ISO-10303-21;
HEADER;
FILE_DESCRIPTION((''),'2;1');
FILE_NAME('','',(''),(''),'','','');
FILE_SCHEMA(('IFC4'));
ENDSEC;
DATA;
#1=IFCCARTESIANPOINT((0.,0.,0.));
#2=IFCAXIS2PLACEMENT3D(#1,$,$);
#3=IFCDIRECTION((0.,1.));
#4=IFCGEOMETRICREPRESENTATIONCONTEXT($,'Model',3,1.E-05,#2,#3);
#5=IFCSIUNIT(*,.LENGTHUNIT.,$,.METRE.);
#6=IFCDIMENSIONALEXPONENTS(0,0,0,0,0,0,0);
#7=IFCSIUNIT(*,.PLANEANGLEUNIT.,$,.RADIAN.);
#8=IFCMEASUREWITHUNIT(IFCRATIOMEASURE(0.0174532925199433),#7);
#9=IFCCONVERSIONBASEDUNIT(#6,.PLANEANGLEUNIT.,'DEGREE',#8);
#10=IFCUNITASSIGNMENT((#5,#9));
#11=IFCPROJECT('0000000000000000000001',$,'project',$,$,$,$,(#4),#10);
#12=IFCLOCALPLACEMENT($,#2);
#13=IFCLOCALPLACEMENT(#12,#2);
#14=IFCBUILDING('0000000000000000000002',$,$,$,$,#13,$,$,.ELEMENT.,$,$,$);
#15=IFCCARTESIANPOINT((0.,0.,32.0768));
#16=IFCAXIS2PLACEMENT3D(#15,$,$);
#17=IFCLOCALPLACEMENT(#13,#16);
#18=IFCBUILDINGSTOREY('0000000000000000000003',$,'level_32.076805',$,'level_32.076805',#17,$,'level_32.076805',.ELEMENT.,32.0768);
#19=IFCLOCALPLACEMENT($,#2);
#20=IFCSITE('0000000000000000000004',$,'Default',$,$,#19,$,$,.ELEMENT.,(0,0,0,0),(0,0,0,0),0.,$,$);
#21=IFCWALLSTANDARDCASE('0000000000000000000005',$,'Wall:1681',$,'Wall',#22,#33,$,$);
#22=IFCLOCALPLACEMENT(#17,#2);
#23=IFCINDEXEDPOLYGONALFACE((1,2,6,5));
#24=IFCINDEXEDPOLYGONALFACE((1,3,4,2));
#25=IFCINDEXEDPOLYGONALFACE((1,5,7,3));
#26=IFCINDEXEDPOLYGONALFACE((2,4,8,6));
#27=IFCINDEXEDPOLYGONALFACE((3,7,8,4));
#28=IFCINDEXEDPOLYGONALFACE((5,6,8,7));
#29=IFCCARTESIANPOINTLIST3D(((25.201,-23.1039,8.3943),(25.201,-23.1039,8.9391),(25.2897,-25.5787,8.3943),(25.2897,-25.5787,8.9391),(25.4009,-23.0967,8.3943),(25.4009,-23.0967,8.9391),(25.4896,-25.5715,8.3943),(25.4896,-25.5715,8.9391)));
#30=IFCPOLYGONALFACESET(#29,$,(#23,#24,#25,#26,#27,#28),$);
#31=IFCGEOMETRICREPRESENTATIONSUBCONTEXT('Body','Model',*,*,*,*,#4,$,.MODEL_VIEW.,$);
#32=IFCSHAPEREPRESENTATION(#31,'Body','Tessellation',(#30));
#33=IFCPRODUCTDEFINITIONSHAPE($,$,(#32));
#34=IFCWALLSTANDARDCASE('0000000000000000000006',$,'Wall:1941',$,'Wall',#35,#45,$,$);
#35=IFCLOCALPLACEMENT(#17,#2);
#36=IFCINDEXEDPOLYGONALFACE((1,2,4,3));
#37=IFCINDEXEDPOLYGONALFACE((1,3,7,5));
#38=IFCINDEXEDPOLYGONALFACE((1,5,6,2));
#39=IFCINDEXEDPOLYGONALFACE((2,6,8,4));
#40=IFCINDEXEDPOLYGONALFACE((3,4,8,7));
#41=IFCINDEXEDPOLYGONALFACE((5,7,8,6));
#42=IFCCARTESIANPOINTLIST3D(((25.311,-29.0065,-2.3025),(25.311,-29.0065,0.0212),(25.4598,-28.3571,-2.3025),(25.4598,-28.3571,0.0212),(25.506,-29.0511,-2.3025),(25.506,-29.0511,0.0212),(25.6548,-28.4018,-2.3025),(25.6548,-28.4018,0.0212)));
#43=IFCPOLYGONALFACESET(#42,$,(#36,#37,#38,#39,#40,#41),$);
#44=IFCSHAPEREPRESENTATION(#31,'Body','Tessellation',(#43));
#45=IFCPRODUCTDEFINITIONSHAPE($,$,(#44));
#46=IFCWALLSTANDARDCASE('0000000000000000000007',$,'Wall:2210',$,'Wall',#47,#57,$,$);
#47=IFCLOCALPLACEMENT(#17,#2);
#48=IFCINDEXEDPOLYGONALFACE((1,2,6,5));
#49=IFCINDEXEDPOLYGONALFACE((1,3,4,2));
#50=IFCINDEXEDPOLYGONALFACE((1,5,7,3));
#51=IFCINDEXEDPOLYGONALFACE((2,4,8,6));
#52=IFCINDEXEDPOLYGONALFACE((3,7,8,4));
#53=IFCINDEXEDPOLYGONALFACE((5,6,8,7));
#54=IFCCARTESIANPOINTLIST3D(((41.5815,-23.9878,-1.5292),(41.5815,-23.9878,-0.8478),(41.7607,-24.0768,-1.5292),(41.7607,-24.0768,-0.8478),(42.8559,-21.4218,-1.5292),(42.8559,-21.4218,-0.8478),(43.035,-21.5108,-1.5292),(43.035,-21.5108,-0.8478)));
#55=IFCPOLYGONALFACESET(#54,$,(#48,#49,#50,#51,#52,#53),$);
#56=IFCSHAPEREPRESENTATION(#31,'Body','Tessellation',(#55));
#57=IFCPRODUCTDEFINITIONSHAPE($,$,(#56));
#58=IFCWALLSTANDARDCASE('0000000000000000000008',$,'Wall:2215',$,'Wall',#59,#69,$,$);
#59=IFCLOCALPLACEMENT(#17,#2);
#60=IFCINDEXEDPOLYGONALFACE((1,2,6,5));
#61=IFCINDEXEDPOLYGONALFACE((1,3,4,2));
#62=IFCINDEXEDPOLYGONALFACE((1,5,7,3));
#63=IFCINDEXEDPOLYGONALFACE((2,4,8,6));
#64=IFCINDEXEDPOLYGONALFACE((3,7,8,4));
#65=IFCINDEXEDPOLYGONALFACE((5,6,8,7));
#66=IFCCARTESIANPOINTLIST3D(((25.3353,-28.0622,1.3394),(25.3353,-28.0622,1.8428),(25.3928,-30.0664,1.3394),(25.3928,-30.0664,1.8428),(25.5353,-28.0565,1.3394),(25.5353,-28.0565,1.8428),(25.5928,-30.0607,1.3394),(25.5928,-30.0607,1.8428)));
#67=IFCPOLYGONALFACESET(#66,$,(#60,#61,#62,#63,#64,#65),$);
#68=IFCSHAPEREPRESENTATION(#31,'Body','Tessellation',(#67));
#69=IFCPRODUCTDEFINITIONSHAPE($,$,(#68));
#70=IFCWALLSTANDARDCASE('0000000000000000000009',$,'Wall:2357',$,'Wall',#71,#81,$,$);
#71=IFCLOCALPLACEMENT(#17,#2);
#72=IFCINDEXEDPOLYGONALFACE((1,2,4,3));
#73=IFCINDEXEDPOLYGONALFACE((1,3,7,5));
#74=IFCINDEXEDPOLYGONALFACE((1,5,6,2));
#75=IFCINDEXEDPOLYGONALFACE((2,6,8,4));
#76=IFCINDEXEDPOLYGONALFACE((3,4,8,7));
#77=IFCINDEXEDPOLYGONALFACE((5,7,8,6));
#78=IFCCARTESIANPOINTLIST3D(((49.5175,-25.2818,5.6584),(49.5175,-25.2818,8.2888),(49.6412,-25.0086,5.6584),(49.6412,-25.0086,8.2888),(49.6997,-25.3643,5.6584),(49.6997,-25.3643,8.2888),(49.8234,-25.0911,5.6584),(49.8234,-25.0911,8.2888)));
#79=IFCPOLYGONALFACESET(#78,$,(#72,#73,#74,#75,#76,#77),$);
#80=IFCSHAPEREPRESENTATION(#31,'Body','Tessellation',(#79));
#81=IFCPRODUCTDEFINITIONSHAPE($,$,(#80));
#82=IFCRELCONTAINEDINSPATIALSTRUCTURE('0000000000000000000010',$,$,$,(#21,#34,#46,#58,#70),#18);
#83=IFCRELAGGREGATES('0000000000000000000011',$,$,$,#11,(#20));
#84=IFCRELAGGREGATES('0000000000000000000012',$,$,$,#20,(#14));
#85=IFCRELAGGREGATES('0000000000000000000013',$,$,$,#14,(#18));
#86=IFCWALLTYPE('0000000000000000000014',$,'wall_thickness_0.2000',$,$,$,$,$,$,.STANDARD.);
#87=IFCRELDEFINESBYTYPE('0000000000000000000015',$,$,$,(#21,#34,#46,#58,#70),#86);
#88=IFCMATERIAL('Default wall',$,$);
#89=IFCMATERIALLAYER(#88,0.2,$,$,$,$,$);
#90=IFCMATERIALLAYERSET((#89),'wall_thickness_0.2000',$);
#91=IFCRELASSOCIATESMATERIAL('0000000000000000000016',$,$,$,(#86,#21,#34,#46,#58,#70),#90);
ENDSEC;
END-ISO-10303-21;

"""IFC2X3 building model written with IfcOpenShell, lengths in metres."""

from ifc_helpers import new_model, entity, si_unit, converted_unit, direction, frame, origin, place, context, subcontext, project, spatial, polyline, outline, extrude, material, layer, layer_set, layer_usage, type_object, element, save


model = new_model("IFC2X3")

# Units and contexts
model_context = context("Model", 3, precision=1e-05, world=origin(), true_north=direction((0.0, 1.0)))
body_context = subcontext(model_context, "Body", "Model", "MODEL_VIEW")
ifc_project = project(units=[si_unit("LENGTHUNIT", "METRE"), converted_unit("PLANEANGLEUNIT", "DEGREE", entity("IfcRatioMeasure", 0.0174532925199433), si_unit("PLANEANGLEUNIT", "RADIAN"), dimensions=[0, 0, 0, 0, 0, 0, 0])], contexts=[model_context])

# Site, building, storey
site_placement = place(None, origin())
site = spatial("IfcSite", under=ifc_project, at=site_placement, Name="Default", CompositionType="ELEMENT", RefLatitude=(0, 0, 0, 0), RefLongitude=(0, 0, 0, 0), RefElevation=0.0)
placement_1 = place(None, origin())
building_placement = place(placement_1, origin())
building = spatial("IfcBuilding", under=site, at=building_placement, CompositionType="ELEMENT")
storey_placement = place(building_placement, frame((0.0, 0.0, 32.0768)))
storey = spatial("IfcBuildingStorey", under=building, at=storey_placement, Name="level_32.076805", ObjectType="level_32.076805", LongName="level_32.076805", CompositionType="ELEMENT", Elevation=32.0768)

# Walls
ifc_material = material(Name="Default wall")
ifc_layer = layer(ifc_material, 0.2)
ifc_layer_set = layer_set([ifc_layer], Name="wall_thickness_0.2000")
ifc_layer_usage = layer_usage(ifc_layer_set, "AXIS2", "POSITIVE", -0.1)
wall_type = type_object("IfcWallType", Name="wall_thickness_0.2000", PredefinedType="STANDARD", material=ifc_layer_set)
placement_2 = place(building_placement, frame((0.0, 0.0, 40.4711)))
wall_1_placement = place(placement_2, frame((25.301, -23.1003, 0.0), z_axis=(0.0, 0.0, 1.0), x_axis=(0.035821, -0.999358, 0.0)))
element("IfcWallStandardCase", 1, at=wall_1_placement, inside=storey, type_object=wall_type, material=ifc_layer_usage, Name="Wall:1681", ObjectType="Wall", context=body_context, shape_type="SweptSolid", body=[
    extrude(outline(polyline([(2.4764, -0.1), (2.4764, 0.1), (0.0, 0.1), (0.0, -0.1), (2.4764, -0.1)])), origin(), (0.0, 0.0, 1.0), 0.5448),
])
placement_3 = place(building_placement, frame((0.0, 0.0, 29.7743)))
wall_2_placement = place(placement_3, frame((25.5573, -28.3794, 0.0), z_axis=(0.0, 0.0, 1.0), x_axis=(-0.223345, -0.97474, 0.0)))
element("IfcWallStandardCase", 2, at=wall_2_placement, inside=storey, type_object=wall_type, material=ifc_layer_usage, Name="Wall:1941", ObjectType="Wall", context=body_context, shape_type="SweptSolid", body=[
    extrude(outline(polyline([(0.6662, -0.1), (0.6662, 0.1), (0.0, 0.1), (0.0, -0.1), (0.6662, -0.1)])), origin(), (0.0, 0.0, 1.0), 2.3238),
])
placement_4 = place(building_placement, frame((0.0, 0.0, 30.5476)))
wall_3_placement = place(placement_4, frame((41.6711, -24.0323, 0.0), z_axis=(0.0, 0.0, 1.0), x_axis=(0.444792, 0.895634, 0.0)))
element("IfcWallStandardCase", 3, at=wall_3_placement, inside=storey, type_object=wall_type, material=ifc_layer_usage, Name="Wall:2210", ObjectType="Wall", context=body_context, shape_type="SweptSolid", body=[
    extrude(outline(polyline([(2.865, -0.1), (2.865, 0.1), (0.0, 0.1), (0.0, -0.1), (2.865, -0.1)])), origin(), (0.0, 0.0, 1.0), 0.6814),
])
placement_5 = place(building_placement, frame((0.0, 0.0, 33.4162)))
wall_4_placement = place(placement_5, frame((25.4353, -28.0594, 0.0), z_axis=(0.0, 0.0, 1.0), x_axis=(0.028679, -0.999589, 0.0)))
element("IfcWallStandardCase", 4, at=wall_4_placement, inside=storey, type_object=wall_type, material=ifc_layer_usage, Name="Wall:2215", ObjectType="Wall", context=body_context, shape_type="SweptSolid", body=[
    extrude(outline(polyline([(2.005, -0.1), (2.005, 0.1), (0.0, 0.1), (0.0, -0.1), (2.005, -0.1)])), origin(), (0.0, 0.0, 1.0), 0.5033),
])
placement_6 = place(building_placement, frame((0.0, 0.0, 37.7352)))
wall_5_placement = place(placement_6, frame((49.6086, -25.3231, 0.0), z_axis=(0.0, 0.0, 1.0), x_axis=(0.412484, 0.910965, 0.0)))
element("IfcWallStandardCase", 5, at=wall_5_placement, inside=storey, type_object=wall_type, material=ifc_layer_usage, Name="Wall:2357", ObjectType="Wall", context=body_context, shape_type="SweptSolid", body=[
    extrude(outline(polyline([(0.3, -0.1), (0.3, 0.1), (0.0, 0.1), (0.0, -0.1), (0.3, -0.1)])), origin(), (0.0, 0.0, 1.0), 2.6304),
])

save(model, "model.ifc")
